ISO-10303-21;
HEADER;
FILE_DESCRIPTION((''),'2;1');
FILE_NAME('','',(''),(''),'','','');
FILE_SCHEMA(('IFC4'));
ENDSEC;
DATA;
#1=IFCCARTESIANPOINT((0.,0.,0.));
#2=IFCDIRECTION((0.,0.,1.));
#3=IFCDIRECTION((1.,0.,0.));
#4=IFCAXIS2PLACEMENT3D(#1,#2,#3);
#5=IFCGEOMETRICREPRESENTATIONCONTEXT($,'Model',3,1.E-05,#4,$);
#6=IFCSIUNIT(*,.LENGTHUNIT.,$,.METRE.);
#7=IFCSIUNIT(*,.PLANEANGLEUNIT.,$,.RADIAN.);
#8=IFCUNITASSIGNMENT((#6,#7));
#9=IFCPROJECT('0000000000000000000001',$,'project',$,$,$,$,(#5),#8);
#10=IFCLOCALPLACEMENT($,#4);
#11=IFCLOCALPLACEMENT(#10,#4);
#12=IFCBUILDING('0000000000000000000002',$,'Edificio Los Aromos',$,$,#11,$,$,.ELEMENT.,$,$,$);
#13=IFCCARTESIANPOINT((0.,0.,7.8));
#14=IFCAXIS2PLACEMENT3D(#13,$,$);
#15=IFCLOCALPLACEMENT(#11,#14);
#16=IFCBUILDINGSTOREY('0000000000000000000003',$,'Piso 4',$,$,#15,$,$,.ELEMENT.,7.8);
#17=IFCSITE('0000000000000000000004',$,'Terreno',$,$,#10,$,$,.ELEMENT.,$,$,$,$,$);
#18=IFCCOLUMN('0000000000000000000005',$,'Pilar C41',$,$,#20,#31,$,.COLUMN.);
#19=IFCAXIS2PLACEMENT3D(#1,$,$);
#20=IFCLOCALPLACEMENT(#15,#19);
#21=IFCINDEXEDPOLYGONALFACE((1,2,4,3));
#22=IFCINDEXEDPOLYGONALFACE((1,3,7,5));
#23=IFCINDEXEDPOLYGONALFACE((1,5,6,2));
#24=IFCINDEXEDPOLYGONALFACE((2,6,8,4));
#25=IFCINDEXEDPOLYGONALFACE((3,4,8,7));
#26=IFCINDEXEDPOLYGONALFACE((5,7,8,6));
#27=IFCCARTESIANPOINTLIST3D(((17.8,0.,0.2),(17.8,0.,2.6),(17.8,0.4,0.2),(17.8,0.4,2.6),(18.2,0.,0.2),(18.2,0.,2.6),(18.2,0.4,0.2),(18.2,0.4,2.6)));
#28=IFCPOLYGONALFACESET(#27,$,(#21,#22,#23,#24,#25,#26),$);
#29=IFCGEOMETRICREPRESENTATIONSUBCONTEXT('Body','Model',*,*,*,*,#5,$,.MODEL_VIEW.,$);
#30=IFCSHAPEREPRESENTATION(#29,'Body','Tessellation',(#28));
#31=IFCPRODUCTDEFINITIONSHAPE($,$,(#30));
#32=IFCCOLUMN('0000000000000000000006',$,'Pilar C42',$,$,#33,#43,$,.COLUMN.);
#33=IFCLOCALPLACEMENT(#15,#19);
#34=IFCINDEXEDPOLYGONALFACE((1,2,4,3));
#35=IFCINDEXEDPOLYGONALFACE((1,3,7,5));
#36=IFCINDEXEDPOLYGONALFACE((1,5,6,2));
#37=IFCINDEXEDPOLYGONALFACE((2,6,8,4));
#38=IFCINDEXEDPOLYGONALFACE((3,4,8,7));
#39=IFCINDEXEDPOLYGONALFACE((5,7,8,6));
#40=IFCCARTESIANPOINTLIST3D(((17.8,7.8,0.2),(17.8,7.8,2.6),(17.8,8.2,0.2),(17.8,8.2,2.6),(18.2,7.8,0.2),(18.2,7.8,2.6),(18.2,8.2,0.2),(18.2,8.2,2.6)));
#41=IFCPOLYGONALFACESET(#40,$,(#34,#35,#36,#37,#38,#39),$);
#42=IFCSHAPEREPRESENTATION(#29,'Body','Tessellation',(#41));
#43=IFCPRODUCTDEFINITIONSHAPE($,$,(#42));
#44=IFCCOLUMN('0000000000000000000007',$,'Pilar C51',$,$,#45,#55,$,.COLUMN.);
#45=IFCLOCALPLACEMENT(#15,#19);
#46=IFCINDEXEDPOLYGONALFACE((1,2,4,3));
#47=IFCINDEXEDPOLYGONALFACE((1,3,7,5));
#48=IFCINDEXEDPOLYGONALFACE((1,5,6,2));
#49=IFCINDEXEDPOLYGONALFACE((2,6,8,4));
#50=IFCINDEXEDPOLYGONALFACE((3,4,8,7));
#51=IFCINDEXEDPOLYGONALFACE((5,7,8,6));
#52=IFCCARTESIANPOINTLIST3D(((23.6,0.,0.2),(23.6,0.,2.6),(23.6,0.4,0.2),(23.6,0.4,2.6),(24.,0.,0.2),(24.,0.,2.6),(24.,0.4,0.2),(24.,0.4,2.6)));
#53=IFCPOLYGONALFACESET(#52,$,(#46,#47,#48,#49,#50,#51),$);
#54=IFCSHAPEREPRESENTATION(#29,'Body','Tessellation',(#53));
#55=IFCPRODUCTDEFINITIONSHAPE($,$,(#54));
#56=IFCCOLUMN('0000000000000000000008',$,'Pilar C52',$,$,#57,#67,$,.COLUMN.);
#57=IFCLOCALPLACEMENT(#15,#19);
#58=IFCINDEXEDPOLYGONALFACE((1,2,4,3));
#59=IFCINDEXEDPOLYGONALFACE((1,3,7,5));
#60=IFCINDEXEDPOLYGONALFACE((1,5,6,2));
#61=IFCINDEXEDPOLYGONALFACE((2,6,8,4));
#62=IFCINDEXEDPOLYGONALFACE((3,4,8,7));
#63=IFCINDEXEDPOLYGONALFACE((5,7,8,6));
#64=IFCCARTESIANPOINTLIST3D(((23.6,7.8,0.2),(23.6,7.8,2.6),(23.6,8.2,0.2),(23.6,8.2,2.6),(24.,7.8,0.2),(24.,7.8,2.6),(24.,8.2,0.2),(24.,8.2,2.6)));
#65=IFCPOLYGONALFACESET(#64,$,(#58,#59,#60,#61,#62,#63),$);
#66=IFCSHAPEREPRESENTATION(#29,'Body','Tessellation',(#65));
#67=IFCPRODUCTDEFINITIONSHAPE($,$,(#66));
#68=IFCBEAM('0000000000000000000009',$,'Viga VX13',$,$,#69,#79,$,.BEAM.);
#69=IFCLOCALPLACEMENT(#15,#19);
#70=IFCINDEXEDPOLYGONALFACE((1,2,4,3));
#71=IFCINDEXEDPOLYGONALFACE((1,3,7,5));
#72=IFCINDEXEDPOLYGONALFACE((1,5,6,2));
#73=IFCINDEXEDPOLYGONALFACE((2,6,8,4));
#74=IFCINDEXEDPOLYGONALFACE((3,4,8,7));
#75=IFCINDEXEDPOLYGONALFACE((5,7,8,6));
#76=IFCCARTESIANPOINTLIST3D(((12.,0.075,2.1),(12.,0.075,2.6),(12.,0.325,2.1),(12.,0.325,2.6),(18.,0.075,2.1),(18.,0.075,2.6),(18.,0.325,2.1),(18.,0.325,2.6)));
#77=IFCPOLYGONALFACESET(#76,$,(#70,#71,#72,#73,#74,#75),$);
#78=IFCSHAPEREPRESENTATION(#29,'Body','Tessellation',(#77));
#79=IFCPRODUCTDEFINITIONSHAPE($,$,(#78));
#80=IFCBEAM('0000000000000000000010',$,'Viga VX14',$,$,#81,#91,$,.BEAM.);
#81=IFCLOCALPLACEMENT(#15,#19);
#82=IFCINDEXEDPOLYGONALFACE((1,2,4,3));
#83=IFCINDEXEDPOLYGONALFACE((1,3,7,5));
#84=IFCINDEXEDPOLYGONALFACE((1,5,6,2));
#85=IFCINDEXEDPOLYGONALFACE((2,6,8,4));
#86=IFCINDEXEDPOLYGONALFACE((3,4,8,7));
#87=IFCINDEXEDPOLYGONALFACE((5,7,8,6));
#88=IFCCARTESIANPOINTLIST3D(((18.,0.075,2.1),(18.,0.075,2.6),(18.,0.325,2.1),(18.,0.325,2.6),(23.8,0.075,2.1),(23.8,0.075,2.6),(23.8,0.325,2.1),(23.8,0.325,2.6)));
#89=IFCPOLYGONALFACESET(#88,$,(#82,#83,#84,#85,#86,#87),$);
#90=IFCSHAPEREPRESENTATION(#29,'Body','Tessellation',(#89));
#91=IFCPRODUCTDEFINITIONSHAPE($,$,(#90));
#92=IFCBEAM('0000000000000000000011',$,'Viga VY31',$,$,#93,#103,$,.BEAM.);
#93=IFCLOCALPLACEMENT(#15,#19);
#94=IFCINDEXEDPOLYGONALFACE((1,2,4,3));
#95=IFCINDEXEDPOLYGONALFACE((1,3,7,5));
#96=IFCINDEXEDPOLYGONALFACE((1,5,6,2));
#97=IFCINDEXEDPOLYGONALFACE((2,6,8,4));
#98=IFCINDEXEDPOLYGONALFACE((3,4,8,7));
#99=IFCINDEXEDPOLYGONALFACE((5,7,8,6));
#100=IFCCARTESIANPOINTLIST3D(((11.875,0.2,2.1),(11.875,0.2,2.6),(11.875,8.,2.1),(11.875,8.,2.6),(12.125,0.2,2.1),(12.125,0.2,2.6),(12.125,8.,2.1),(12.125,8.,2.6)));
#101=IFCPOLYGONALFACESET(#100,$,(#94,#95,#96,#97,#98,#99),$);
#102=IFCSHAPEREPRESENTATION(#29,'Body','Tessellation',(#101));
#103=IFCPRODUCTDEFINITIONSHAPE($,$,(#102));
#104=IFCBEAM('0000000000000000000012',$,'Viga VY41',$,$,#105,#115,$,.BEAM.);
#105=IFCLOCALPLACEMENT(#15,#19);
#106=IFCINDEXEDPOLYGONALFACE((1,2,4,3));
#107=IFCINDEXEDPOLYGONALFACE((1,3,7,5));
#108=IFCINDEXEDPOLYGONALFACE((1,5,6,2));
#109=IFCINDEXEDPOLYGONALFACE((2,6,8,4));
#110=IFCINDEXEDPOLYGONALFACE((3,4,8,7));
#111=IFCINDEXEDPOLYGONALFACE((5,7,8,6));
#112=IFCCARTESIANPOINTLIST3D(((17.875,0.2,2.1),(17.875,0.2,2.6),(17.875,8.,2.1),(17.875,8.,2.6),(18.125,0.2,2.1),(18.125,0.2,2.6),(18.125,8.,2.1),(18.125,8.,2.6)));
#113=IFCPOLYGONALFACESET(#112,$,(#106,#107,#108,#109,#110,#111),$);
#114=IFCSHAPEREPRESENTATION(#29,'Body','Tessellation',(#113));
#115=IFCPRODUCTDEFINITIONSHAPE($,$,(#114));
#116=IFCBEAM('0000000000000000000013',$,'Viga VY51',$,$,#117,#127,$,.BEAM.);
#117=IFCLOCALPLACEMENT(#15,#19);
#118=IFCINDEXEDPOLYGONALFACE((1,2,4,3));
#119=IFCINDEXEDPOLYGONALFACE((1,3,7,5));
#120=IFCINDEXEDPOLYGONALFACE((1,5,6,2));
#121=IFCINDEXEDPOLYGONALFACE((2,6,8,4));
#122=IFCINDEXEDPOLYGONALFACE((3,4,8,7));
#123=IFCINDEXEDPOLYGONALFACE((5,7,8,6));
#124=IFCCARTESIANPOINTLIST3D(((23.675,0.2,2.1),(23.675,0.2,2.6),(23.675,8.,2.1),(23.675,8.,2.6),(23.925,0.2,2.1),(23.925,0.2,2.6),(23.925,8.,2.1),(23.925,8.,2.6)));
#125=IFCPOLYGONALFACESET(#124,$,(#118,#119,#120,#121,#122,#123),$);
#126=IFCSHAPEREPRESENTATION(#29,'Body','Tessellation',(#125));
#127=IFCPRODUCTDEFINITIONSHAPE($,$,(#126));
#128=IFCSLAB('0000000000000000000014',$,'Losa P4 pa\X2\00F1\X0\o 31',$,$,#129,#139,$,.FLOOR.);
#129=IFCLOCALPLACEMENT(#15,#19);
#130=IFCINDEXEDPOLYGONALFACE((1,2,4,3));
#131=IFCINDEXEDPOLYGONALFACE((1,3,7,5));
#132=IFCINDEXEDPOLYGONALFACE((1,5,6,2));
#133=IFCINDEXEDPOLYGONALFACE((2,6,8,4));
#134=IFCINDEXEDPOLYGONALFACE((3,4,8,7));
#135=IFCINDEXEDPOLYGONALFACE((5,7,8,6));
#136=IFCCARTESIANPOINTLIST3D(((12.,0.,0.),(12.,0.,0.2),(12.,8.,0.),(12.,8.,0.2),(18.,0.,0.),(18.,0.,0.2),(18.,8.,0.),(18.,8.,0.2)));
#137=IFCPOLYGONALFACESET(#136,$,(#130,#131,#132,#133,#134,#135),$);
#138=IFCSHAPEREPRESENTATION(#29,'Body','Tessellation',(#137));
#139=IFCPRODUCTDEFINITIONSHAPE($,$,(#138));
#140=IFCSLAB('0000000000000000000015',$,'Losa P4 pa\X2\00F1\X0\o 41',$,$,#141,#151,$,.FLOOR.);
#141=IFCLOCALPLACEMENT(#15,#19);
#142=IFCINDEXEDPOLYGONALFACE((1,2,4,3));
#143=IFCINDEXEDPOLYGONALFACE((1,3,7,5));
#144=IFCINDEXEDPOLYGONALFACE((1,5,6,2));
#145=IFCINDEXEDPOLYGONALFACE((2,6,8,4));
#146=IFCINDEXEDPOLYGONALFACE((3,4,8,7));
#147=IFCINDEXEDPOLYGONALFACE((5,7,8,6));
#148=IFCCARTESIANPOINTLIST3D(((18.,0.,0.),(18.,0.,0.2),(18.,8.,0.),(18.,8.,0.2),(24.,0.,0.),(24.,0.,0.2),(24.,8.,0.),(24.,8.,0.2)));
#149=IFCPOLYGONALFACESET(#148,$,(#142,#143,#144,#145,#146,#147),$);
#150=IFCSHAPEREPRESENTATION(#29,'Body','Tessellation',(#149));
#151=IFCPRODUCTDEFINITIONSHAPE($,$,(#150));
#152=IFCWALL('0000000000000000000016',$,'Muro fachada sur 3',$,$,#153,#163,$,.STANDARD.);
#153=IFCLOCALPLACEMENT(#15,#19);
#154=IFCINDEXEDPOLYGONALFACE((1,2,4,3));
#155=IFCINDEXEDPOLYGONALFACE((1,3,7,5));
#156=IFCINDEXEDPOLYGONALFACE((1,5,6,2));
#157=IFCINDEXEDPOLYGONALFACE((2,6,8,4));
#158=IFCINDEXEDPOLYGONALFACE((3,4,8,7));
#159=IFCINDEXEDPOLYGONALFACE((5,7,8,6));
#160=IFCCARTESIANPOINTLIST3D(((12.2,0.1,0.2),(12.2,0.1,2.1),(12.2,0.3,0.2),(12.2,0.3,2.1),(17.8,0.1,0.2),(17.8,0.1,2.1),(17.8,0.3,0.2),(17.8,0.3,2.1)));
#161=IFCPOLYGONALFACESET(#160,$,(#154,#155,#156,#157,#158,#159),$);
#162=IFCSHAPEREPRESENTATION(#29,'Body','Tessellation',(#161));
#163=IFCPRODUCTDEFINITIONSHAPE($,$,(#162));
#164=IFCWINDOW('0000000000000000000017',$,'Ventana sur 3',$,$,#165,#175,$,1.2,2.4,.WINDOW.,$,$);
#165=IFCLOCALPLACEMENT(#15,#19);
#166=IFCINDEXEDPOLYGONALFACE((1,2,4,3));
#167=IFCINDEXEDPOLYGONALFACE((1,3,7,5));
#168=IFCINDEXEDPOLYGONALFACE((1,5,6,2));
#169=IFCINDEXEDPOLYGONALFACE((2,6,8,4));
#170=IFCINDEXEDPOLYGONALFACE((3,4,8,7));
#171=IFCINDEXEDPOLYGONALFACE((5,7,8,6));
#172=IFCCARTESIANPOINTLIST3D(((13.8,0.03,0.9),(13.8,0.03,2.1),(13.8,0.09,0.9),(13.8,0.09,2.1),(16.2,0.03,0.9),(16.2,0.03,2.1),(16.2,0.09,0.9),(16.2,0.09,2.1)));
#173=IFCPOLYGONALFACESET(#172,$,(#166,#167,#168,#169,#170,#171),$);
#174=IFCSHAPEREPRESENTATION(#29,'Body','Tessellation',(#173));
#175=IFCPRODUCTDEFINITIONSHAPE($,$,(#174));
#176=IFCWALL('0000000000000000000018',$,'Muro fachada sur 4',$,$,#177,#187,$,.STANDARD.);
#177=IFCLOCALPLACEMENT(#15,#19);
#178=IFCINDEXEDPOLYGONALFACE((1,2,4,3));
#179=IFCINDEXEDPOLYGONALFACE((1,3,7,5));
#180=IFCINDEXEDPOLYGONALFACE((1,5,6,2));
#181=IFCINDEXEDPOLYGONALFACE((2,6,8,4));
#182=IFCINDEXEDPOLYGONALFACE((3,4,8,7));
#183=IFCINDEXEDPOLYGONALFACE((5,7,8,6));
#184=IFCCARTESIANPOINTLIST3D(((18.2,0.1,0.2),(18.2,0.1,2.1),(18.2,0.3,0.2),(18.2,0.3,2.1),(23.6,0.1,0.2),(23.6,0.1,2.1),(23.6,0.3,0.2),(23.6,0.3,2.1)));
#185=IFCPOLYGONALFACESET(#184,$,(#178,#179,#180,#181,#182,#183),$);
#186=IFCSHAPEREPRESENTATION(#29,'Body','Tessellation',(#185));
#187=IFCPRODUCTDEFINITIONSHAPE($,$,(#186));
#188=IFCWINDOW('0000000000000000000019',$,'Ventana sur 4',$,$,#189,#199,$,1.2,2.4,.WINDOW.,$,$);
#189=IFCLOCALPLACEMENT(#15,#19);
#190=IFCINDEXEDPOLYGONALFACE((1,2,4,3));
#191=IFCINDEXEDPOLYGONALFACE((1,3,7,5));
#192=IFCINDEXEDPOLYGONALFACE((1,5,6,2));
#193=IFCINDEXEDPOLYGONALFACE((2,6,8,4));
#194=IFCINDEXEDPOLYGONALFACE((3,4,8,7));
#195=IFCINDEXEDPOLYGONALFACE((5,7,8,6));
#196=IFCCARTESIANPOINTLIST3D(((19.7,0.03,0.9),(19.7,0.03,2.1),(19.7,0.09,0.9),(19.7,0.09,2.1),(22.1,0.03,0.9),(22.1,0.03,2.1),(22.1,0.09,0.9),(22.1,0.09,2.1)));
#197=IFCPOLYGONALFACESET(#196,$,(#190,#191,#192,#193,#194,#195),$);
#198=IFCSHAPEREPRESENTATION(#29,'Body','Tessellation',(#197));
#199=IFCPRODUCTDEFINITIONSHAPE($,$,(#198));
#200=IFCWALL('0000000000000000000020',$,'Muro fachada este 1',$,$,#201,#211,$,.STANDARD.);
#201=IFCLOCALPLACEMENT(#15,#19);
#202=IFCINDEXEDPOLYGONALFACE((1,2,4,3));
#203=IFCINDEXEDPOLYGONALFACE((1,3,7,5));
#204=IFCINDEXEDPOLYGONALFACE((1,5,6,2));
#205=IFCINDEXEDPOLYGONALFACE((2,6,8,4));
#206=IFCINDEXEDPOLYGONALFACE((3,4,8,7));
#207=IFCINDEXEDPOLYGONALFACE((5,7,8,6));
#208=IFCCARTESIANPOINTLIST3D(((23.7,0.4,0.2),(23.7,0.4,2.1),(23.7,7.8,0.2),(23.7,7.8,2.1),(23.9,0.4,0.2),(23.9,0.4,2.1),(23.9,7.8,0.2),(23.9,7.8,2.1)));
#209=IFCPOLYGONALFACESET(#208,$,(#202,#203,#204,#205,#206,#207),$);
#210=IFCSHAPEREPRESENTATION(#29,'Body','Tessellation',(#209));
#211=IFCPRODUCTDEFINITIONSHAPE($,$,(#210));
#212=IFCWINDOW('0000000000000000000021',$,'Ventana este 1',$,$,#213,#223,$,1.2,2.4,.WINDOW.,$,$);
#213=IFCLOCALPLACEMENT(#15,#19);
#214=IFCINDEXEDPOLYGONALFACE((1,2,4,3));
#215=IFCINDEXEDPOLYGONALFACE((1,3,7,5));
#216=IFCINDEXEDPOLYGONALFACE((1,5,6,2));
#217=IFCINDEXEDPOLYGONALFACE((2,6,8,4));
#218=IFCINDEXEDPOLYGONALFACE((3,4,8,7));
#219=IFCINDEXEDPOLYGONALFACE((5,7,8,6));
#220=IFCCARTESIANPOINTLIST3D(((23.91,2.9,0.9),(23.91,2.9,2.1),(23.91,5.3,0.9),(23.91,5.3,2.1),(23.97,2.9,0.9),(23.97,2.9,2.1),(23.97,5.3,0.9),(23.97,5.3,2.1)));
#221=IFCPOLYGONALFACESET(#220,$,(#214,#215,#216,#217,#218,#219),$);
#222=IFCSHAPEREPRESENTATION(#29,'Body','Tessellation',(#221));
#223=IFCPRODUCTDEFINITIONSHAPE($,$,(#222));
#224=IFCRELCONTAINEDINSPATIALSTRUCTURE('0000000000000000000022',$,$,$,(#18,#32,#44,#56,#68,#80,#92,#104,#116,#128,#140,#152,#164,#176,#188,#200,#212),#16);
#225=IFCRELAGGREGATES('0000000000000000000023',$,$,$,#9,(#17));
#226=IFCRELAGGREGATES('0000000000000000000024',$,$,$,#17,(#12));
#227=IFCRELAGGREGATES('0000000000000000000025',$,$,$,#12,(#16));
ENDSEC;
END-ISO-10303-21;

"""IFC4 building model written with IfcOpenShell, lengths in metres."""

from ifc_helpers import new_model, si_unit, frame, frame_2d, origin_with_axes, place, context, subcontext, project, spatial, rectangle, extrude, element, save


model = new_model("IFC4")

# Units and contexts
model_context = context("Model", 3, precision=1e-05, world=origin_with_axes())
body_context = subcontext(model_context, "Body", "Model", "MODEL_VIEW")
ifc_project = project(units=[si_unit("LENGTHUNIT", "METRE"), si_unit("PLANEANGLEUNIT", "RADIAN")], contexts=[model_context])

# Site, building, storey
site_placement = place(None, origin_with_axes())
site = spatial("IfcSite", under=ifc_project, at=site_placement, Name="Terreno", CompositionType="ELEMENT")
building_placement = place(site_placement, origin_with_axes())
building = spatial("IfcBuilding", under=site, at=building_placement, Name="Edificio Los Aromos", CompositionType="ELEMENT")
storey_placement = place(building_placement, frame((0.0, 0.0, 7.8)))
storey = spatial("IfcBuildingStorey", under=building, at=storey_placement, Name="Piso 4", CompositionType="ELEMENT", Elevation=7.8)

# Columns
for number, where, name in (
    (1, (17.8, 0.0, 0.2), "Pilar C41"),
    (2, (17.8, 7.8, 0.2), "Pilar C42"),
    (3, (23.6, 0.0, 0.2), "Pilar C51"),
    (4, (23.6, 7.8, 0.2), "Pilar C52"),
):
    element("IfcColumn", number, at=place(storey_placement, frame(where)), inside=storey, Name=name, PredefinedType="COLUMN", context=body_context, shape_type="SweptSolid", body=[
        extrude(rectangle(XDim=0.4, YDim=0.4, at=frame_2d((0.2, 0.2))), origin_with_axes(), (0.0, 0.0, 1.0), 2.4),
    ])

# Beams
beam_1_placement = place(storey_placement, frame((12.0, 0.075, 2.1)))
element("IfcBeam", 5, at=beam_1_placement, inside=storey, Name="Viga VX13", PredefinedType="BEAM", context=body_context, shape_type="SweptSolid", body=[
    extrude(rectangle(XDim=6.0, YDim=0.25, at=frame_2d((3.0, 0.125))), origin_with_axes(), (0.0, 0.0, 1.0), 0.5),
])
beam_2_placement = place(storey_placement, frame((18.0, 0.075, 2.1)))
element("IfcBeam", 6, at=beam_2_placement, inside=storey, Name="Viga VX14", PredefinedType="BEAM", context=body_context, shape_type="SweptSolid", body=[
    extrude(rectangle(XDim=5.8, YDim=0.25, at=frame_2d((2.9, 0.125))), origin_with_axes(), (0.0, 0.0, 1.0), 0.5),
])
for number, where, name in (
    (7, (11.875, 0.2, 2.1), "Viga VY31"),
    (8, (17.875, 0.2, 2.1), "Viga VY41"),
    (9, (23.675, 0.2, 2.1), "Viga VY51"),
):
    element("IfcBeam", number, at=place(storey_placement, frame(where)), inside=storey, Name=name, PredefinedType="BEAM", context=body_context, shape_type="SweptSolid", body=[
        extrude(rectangle(XDim=0.25, YDim=7.8, at=frame_2d((0.125, 3.9))), origin_with_axes(), (0.0, 0.0, 1.0), 0.5),
    ])

# Slabs
for number, where, name in (
    (10, (12.0, 0.0, 0.0), "Losa P4 paño 31"),
    (11, (18.0, 0.0, 0.0), "Losa P4 paño 41"),
):
    element("IfcSlab", number, at=place(storey_placement, frame(where)), inside=storey, Name=name, PredefinedType="FLOOR", context=body_context, shape_type="SweptSolid", body=[
        extrude(rectangle(XDim=6.0, YDim=8.0, at=frame_2d((3.0, 4.0))), origin_with_axes(), (0.0, 0.0, 1.0), 0.2),
    ])

# Wall
wall_1_placement = place(storey_placement, frame((12.2, 0.1, 0.2)))
element("IfcWall", 12, at=wall_1_placement, inside=storey, Name="Muro fachada sur 3", PredefinedType="STANDARD", context=body_context, shape_type="SweptSolid", body=[
    extrude(rectangle(XDim=5.6, YDim=0.2, at=frame_2d((2.8, 0.1))), origin_with_axes(), (0.0, 0.0, 1.0), 1.9),
])

# Window
window_1_placement = place(storey_placement, frame((13.8, 0.03, 0.9)))
element("IfcWindow", 13, at=window_1_placement, inside=storey, Name="Ventana sur 3", OverallHeight=1.2, OverallWidth=2.4, PredefinedType="WINDOW", context=body_context, shape_type="SweptSolid", body=[
    extrude(rectangle(XDim=2.4, YDim=0.06, at=frame_2d((1.2, 0.03))), origin_with_axes(), (0.0, 0.0, 1.0), 1.2),
])

# Wall
wall_2_placement = place(storey_placement, frame((18.2, 0.1, 0.2)))
element("IfcWall", 14, at=wall_2_placement, inside=storey, Name="Muro fachada sur 4", PredefinedType="STANDARD", context=body_context, shape_type="SweptSolid", body=[
    extrude(rectangle(XDim=5.4, YDim=0.2, at=frame_2d((2.7, 0.1))), origin_with_axes(), (0.0, 0.0, 1.0), 1.9),
])

# Window
window_2_placement = place(storey_placement, frame((19.7, 0.03, 0.9)))
element("IfcWindow", 15, at=window_2_placement, inside=storey, Name="Ventana sur 4", OverallHeight=1.2, OverallWidth=2.4, PredefinedType="WINDOW", context=body_context, shape_type="SweptSolid", body=[
    extrude(rectangle(XDim=2.4, YDim=0.06, at=frame_2d((1.2, 0.03))), origin_with_axes(), (0.0, 0.0, 1.0), 1.2),
])

# Wall
wall_3_placement = place(storey_placement, frame((23.7, 0.4, 0.2)))
element("IfcWall", 16, at=wall_3_placement, inside=storey, Name="Muro fachada este 1", PredefinedType="STANDARD", context=body_context, shape_type="SweptSolid", body=[
    extrude(rectangle(XDim=0.2, YDim=7.4, at=frame_2d((0.1, 3.7))), origin_with_axes(), (0.0, 0.0, 1.0), 1.9),
])

# Window
window_3_placement = place(storey_placement, frame((23.91, 2.9, 0.9)))
element("IfcWindow", 17, at=window_3_placement, inside=storey, Name="Ventana este 1", OverallHeight=1.2, OverallWidth=2.4, PredefinedType="WINDOW", context=body_context, shape_type="SweptSolid", body=[
    extrude(rectangle(XDim=0.06, YDim=2.4, at=frame_2d((0.03, 1.2))), origin_with_axes(), (0.0, 0.0, 1.0), 1.2),
])

save(model, "model.ifc")
